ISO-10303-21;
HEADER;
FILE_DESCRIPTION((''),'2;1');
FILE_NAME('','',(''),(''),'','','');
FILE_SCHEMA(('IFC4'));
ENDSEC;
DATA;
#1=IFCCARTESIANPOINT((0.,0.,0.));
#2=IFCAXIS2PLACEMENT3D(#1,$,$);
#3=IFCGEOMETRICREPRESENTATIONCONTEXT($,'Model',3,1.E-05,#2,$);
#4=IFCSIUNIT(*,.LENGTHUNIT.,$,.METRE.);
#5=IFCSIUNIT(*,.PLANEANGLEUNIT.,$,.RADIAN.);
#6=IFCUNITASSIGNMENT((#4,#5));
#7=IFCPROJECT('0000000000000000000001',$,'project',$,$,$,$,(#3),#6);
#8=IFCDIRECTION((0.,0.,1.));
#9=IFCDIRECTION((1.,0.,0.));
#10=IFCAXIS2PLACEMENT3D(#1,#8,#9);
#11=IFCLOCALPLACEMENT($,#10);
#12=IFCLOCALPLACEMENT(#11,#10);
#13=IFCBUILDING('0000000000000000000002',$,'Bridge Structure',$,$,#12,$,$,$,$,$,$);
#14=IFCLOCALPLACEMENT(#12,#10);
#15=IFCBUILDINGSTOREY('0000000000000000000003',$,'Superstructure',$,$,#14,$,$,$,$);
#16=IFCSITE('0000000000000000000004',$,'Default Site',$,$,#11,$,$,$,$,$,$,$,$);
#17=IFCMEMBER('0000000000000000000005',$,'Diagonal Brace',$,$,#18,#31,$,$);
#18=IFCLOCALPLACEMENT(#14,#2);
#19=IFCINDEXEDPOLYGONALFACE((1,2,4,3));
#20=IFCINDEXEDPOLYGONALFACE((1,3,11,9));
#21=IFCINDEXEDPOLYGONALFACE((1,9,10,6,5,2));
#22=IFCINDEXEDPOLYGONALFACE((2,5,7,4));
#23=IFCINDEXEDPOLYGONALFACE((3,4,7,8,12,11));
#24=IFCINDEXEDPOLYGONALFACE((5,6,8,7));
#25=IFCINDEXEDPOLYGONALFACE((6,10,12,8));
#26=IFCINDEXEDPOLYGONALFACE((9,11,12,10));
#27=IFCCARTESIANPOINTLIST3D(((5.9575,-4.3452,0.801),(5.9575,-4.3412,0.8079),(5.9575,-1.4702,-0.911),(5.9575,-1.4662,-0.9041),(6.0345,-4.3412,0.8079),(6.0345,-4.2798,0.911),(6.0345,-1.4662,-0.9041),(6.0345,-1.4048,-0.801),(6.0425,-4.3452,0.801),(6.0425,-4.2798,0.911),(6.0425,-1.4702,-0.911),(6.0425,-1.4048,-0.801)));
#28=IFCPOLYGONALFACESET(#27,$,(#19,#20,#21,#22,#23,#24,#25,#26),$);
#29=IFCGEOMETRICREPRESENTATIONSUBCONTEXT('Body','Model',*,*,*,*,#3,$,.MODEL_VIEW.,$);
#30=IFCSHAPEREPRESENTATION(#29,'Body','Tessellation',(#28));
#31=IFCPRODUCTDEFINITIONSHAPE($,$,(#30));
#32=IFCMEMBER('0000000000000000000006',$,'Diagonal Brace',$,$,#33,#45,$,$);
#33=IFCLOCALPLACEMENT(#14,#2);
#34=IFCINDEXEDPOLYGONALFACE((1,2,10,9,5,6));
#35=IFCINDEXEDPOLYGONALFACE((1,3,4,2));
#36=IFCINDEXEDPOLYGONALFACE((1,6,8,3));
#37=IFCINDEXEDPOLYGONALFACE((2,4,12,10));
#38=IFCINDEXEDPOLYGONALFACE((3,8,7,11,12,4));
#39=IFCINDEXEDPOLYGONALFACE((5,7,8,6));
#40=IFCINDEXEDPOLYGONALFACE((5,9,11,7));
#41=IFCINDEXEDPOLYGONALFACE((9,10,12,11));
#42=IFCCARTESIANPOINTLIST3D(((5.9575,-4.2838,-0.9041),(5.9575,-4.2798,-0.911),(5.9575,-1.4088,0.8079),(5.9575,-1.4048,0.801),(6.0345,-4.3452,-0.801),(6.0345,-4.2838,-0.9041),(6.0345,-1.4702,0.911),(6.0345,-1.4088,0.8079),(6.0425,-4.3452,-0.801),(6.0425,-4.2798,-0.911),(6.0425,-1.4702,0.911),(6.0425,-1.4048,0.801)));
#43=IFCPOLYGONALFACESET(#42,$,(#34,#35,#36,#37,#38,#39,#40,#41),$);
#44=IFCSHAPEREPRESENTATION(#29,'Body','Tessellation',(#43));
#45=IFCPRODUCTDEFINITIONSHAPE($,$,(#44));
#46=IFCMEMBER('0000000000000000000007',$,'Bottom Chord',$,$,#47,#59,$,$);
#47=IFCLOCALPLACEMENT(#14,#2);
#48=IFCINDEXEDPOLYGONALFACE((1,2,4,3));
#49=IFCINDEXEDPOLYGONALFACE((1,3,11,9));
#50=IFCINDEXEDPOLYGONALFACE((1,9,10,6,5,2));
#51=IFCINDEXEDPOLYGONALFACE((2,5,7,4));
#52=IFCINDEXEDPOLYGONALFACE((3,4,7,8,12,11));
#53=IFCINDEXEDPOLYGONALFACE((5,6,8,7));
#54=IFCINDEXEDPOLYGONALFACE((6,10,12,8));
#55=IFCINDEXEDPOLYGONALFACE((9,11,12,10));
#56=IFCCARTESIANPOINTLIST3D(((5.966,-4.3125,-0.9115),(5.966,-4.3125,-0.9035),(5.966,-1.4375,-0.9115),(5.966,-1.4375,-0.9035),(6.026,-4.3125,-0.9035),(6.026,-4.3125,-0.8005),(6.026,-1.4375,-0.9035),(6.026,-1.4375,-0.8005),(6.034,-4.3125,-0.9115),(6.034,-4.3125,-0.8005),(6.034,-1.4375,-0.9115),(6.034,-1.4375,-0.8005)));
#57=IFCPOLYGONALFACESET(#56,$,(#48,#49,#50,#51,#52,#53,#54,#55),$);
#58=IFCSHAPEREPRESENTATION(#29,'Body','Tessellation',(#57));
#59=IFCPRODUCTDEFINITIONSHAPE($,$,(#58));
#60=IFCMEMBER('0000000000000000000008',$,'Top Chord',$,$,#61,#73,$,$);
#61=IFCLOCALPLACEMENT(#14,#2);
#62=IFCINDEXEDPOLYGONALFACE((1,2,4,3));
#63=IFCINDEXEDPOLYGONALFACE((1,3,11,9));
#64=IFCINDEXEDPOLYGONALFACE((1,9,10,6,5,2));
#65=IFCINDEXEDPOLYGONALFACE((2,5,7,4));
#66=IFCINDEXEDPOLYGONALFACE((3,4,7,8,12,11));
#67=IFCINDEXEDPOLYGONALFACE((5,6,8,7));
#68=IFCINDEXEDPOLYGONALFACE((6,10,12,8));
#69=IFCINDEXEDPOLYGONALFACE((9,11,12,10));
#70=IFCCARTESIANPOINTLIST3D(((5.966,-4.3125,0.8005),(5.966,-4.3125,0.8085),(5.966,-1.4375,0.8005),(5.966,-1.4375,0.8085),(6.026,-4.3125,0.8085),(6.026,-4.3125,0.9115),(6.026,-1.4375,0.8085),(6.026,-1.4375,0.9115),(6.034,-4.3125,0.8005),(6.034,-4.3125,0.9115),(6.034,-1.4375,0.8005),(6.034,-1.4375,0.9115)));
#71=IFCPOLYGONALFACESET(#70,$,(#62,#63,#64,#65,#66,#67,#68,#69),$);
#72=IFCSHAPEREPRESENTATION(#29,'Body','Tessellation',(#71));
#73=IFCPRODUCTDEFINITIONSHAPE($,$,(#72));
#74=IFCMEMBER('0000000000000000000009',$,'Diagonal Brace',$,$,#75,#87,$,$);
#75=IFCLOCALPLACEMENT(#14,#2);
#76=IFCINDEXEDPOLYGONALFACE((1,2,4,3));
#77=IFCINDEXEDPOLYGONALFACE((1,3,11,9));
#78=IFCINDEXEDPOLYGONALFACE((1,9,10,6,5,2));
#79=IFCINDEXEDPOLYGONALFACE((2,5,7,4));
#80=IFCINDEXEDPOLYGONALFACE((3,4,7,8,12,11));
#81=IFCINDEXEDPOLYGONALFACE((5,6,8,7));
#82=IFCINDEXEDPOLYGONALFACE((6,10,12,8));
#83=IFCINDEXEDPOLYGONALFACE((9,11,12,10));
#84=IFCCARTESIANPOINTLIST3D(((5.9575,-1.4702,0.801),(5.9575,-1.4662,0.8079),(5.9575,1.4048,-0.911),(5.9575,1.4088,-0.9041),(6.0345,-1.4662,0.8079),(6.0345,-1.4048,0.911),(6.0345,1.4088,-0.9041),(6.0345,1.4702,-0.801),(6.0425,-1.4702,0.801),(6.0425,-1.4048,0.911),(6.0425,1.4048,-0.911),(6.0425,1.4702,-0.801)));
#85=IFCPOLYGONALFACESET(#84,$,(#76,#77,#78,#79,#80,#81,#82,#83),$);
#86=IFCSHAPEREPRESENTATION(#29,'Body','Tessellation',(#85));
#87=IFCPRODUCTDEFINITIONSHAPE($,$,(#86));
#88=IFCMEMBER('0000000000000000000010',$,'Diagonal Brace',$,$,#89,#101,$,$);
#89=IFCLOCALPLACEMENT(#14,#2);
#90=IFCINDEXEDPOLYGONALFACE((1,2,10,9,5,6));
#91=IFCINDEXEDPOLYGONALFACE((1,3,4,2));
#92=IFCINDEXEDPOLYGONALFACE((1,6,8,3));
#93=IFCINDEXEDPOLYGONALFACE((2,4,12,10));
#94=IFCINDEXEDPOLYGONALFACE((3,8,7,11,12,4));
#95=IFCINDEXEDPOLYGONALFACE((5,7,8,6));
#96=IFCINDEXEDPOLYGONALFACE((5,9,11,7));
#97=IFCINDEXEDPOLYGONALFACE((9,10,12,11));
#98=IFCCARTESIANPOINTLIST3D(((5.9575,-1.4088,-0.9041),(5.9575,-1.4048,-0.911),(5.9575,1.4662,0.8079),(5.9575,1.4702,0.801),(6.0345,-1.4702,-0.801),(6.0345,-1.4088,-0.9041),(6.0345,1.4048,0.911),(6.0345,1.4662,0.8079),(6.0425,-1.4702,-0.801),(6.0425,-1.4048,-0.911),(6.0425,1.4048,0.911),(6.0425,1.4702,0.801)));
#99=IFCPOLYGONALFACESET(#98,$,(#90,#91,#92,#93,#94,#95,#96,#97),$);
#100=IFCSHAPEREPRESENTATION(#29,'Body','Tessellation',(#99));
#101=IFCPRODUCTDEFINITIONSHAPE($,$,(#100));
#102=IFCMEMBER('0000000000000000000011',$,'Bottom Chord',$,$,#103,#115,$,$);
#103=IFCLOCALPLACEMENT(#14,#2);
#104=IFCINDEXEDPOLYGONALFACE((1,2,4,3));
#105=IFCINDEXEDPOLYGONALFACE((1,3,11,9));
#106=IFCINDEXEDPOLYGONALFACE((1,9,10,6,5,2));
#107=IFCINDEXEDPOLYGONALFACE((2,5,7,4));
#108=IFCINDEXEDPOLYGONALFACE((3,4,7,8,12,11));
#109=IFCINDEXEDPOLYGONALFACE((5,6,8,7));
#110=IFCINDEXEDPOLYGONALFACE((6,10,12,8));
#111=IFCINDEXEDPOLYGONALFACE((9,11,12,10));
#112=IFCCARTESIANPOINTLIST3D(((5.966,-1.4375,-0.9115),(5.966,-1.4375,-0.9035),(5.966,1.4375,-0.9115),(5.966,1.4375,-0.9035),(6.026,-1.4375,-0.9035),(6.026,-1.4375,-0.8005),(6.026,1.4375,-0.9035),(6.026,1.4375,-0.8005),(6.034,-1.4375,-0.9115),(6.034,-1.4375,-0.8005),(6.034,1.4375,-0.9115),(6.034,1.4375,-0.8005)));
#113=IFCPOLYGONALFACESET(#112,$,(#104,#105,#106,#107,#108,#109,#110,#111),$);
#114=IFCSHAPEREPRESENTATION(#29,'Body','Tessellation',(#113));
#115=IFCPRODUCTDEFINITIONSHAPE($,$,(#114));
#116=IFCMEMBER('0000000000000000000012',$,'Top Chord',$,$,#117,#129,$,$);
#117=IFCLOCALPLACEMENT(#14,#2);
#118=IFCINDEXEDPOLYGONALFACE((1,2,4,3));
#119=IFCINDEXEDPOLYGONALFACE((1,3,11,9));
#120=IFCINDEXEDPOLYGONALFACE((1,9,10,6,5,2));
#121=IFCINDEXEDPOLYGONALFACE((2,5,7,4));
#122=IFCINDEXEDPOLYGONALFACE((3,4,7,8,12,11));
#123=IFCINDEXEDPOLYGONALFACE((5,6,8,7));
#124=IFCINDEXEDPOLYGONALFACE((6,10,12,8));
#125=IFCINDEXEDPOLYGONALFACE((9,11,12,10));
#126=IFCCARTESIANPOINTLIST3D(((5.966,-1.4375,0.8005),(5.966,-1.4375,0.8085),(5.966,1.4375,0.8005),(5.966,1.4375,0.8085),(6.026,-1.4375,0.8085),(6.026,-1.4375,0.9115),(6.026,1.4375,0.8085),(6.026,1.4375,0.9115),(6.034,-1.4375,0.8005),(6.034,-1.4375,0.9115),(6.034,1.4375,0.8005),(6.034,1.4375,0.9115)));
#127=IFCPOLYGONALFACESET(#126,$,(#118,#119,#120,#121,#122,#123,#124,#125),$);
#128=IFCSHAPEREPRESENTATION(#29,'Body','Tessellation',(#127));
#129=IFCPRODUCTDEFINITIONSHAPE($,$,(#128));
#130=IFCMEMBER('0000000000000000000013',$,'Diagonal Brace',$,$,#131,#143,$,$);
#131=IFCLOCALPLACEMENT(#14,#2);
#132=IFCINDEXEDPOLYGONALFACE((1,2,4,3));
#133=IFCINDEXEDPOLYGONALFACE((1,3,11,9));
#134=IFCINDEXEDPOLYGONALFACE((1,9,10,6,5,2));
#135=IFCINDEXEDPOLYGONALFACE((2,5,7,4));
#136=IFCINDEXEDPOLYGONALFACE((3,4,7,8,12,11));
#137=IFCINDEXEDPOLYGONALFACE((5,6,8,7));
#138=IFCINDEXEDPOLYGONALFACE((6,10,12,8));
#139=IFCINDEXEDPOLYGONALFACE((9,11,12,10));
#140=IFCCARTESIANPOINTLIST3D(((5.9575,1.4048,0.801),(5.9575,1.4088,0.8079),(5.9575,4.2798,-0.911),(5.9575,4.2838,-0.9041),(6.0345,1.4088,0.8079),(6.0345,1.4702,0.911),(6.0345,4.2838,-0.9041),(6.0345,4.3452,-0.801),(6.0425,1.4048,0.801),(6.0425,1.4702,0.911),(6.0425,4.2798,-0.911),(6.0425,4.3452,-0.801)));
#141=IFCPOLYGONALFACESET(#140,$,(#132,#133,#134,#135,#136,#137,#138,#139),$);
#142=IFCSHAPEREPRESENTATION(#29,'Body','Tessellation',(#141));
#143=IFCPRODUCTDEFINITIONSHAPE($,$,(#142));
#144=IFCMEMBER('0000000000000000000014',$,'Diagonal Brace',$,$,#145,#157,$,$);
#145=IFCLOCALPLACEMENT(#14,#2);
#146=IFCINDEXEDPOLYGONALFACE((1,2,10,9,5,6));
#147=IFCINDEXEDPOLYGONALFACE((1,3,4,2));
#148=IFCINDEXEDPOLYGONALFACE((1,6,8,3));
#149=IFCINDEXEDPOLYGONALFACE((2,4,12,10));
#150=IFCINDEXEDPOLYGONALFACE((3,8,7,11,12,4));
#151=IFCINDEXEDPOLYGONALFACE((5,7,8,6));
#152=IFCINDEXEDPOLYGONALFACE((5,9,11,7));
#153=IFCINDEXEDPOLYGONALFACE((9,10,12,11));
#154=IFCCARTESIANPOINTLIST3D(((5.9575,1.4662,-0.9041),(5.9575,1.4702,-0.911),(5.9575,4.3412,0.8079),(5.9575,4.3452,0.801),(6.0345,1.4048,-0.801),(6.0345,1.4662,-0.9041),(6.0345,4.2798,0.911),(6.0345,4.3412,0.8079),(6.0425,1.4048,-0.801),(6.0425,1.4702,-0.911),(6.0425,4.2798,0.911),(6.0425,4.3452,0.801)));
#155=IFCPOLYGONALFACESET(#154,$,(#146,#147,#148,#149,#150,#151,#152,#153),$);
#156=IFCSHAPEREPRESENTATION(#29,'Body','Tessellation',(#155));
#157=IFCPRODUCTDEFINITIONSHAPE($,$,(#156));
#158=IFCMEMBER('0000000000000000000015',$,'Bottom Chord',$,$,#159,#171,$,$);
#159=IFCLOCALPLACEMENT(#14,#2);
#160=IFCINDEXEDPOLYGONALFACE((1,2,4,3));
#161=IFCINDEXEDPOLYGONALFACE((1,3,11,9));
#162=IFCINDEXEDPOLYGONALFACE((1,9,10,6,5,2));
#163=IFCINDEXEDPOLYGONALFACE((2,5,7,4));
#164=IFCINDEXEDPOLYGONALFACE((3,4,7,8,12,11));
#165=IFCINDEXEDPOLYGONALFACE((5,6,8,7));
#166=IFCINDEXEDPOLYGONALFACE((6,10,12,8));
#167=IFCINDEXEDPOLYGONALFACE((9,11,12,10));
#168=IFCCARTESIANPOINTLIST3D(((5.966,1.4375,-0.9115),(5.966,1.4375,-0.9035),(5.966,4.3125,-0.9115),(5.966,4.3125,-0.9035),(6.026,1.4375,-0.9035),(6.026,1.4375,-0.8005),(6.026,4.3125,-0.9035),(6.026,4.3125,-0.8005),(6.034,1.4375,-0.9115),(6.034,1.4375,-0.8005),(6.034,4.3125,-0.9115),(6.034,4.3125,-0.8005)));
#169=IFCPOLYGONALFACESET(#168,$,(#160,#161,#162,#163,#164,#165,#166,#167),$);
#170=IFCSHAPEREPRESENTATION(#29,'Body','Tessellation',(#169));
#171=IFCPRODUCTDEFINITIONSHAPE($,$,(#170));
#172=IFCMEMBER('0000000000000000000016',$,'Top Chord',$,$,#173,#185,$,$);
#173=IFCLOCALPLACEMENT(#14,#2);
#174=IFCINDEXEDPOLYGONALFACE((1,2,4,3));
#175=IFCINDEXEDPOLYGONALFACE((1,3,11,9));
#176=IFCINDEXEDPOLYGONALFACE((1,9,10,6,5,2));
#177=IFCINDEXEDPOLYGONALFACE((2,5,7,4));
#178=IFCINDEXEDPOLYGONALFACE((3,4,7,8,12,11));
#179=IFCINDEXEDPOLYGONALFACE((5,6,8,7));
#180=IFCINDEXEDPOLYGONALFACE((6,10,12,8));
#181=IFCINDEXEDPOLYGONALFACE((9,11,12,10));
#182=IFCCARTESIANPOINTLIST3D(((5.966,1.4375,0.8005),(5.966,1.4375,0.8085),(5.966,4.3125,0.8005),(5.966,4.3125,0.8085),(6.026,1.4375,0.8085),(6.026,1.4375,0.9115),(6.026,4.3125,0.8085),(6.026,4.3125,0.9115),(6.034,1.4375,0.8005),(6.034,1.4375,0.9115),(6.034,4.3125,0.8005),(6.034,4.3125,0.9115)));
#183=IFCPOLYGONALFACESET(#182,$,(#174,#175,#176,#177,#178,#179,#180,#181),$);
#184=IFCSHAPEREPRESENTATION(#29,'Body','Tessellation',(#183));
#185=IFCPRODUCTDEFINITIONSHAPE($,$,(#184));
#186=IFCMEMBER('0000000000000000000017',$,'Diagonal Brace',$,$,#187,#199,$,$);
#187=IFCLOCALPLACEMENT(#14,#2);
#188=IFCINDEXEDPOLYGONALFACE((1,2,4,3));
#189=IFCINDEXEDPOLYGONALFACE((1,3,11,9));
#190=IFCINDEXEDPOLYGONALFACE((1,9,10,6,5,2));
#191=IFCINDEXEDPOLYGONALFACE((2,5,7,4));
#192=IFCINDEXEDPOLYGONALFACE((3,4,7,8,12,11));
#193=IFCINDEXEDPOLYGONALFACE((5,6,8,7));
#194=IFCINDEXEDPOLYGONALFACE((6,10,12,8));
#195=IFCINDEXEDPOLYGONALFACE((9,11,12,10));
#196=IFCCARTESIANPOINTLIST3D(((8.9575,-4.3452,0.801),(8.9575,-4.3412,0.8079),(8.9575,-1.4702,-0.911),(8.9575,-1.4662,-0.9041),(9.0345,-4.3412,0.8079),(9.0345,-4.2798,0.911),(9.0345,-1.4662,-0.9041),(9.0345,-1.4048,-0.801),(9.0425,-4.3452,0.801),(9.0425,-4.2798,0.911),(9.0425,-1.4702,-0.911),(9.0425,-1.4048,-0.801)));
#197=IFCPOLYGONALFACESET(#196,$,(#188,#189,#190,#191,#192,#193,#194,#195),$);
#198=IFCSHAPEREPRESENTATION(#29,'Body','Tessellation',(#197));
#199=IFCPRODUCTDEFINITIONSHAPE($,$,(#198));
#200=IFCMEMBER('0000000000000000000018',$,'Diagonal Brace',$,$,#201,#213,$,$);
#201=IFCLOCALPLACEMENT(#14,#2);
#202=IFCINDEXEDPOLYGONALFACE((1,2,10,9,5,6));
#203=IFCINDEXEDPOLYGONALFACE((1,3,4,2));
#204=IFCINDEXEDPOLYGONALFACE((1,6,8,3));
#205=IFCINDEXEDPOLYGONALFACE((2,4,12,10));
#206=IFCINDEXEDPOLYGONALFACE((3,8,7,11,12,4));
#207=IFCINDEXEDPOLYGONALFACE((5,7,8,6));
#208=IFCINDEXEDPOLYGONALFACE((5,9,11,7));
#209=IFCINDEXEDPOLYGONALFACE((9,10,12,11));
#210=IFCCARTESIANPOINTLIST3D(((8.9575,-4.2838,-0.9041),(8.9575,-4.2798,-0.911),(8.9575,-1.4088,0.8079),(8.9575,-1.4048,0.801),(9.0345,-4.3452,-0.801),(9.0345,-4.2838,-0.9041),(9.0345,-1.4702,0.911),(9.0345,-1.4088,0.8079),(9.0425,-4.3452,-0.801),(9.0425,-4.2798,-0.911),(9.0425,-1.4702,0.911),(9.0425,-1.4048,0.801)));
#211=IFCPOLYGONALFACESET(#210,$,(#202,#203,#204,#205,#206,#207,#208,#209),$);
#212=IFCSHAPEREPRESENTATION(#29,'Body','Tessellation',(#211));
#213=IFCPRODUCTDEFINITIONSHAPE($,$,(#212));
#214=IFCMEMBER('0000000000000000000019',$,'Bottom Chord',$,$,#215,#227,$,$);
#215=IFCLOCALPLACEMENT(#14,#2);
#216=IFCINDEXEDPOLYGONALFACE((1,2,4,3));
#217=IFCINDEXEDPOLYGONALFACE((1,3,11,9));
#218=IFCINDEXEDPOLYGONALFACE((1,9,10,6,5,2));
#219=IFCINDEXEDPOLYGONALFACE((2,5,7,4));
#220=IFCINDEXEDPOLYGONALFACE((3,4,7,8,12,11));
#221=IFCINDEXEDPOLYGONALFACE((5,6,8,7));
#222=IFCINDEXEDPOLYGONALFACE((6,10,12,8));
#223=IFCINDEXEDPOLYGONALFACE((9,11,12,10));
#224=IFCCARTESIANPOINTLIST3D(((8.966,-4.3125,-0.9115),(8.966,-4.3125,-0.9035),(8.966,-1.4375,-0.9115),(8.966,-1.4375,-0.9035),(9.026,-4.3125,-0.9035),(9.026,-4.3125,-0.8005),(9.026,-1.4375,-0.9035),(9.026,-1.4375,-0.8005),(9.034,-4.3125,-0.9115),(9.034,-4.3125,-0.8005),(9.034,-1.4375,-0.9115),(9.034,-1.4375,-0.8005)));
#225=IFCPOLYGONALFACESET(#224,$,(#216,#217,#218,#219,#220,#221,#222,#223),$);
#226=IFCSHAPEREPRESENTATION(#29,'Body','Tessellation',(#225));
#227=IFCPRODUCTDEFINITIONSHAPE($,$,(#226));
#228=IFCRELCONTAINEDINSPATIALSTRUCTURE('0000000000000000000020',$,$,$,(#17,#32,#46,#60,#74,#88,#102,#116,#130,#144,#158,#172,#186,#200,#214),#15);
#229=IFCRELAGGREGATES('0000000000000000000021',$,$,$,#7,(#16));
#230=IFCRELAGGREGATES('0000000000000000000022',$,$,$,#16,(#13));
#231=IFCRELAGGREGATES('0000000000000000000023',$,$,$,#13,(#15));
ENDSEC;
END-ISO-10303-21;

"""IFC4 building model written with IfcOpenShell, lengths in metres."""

from ifc_helpers import new_model, si_unit, frame, origin, origin_with_axes, origin_2d_with_axis, place, context, subcontext, project, spatial, l_section, extrude, element, save


model = new_model("IFC4")

# Units and contexts
model_context = context("Model", 3, precision=1e-05, world=origin())
body_context = subcontext(model_context, "Body", "Model", "MODEL_VIEW")
ifc_project = project(units=[si_unit("LENGTHUNIT", "METRE"), si_unit("PLANEANGLEUNIT", "RADIAN")], contexts=[model_context])

# Site, building, storey
site_placement = place(None, origin_with_axes())
site = spatial("IfcSite", under=ifc_project, at=site_placement, Name="Default Site")
building_placement = place(site_placement, origin_with_axes())
building = spatial("IfcBuilding", under=site, at=building_placement, Name="Bridge Structure")
storey_placement = place(building_placement, origin_with_axes())
storey = spatial("IfcBuildingStorey", under=building, at=storey_placement, Name="Superstructure")

# Members
for number, where, z_axis, x_axis, name in (
    (1, (6.0, -4.3125, 0.856), (0.0, 0.859202, -0.511636), (-1.0, 0.0, 0.0), "Diagonal Brace"),
    (2, (6.0, -4.3125, -0.856), (0.0, 0.859202, 0.511636), (-1.0, 0.0, 0.0), "Diagonal Brace"),
):
    element("IfcMember", number, at=place(storey_placement, frame(where, z_axis=z_axis, x_axis=x_axis)), inside=storey, Name=name, context=body_context, shape_type="SweptSolid", body=[
        extrude(l_section(Depth=0.128, Width=0.085, Thickness=0.008, at=origin_2d_with_axis()), origin_with_axes(), (0.0, 0.0, 1.0), 3.3461),
    ])
for number, where, z_axis, x_axis, name in (
    (3, (6.0, -4.3125, -0.856), (0.0, 1.0, 0.0), (-1.0, 0.0, 0.0), "Bottom Chord"),
    (4, (6.0, -4.3125, 0.856), (0.0, 1.0, 0.0), (-1.0, 0.0, 0.0), "Top Chord"),
):
    element("IfcMember", number, at=place(storey_placement, frame(where, z_axis=z_axis, x_axis=x_axis)), inside=storey, Name=name, context=body_context, shape_type="SweptSolid", body=[
        extrude(l_section(Depth=0.111, Width=0.068, Thickness=0.008, at=origin_2d_with_axis()), origin_with_axes(), (0.0, 0.0, 1.0), 2.875),
    ])
for number, where, z_axis, x_axis, name in (
    (5, (6.0, -1.4375, 0.856), (0.0, 0.859202, -0.511636), (-1.0, 0.0, 0.0), "Diagonal Brace"),
    (6, (6.0, -1.4375, -0.856), (0.0, 0.859202, 0.511636), (-1.0, 0.0, 0.0), "Diagonal Brace"),
):
    element("IfcMember", number, at=place(storey_placement, frame(where, z_axis=z_axis, x_axis=x_axis)), inside=storey, Name=name, context=body_context, shape_type="SweptSolid", body=[
        extrude(l_section(Depth=0.128, Width=0.085, Thickness=0.008, at=origin_2d_with_axis()), origin_with_axes(), (0.0, 0.0, 1.0), 3.3461),
    ])
for number, where, z_axis, x_axis, name in (
    (7, (6.0, -1.4375, -0.856), (0.0, 1.0, 0.0), (-1.0, 0.0, 0.0), "Bottom Chord"),
    (8, (6.0, -1.4375, 0.856), (0.0, 1.0, 0.0), (-1.0, 0.0, 0.0), "Top Chord"),
):
    element("IfcMember", number, at=place(storey_placement, frame(where, z_axis=z_axis, x_axis=x_axis)), inside=storey, Name=name, context=body_context, shape_type="SweptSolid", body=[
        extrude(l_section(Depth=0.111, Width=0.068, Thickness=0.008, at=origin_2d_with_axis()), origin_with_axes(), (0.0, 0.0, 1.0), 2.875),
    ])
for number, where, z_axis, x_axis, name in (
    (9, (6.0, 1.4375, 0.856), (0.0, 0.859202, -0.511636), (-1.0, 0.0, 0.0), "Diagonal Brace"),
    (10, (6.0, 1.4375, -0.856), (0.0, 0.859202, 0.511636), (-1.0, 0.0, 0.0), "Diagonal Brace"),
):
    element("IfcMember", number, at=place(storey_placement, frame(where, z_axis=z_axis, x_axis=x_axis)), inside=storey, Name=name, context=body_context, shape_type="SweptSolid", body=[
        extrude(l_section(Depth=0.128, Width=0.085, Thickness=0.008, at=origin_2d_with_axis()), origin_with_axes(), (0.0, 0.0, 1.0), 3.3461),
    ])
for number, where, z_axis, x_axis, name in (
    (11, (6.0, 1.4375, -0.856), (0.0, 1.0, 0.0), (-1.0, 0.0, 0.0), "Bottom Chord"),
    (12, (6.0, 1.4375, 0.856), (0.0, 1.0, 0.0), (-1.0, 0.0, 0.0), "Top Chord"),
):
    element("IfcMember", number, at=place(storey_placement, frame(where, z_axis=z_axis, x_axis=x_axis)), inside=storey, Name=name, context=body_context, shape_type="SweptSolid", body=[
        extrude(l_section(Depth=0.111, Width=0.068, Thickness=0.008, at=origin_2d_with_axis()), origin_with_axes(), (0.0, 0.0, 1.0), 2.875),
    ])
for number, where, z_axis, x_axis, name in (
    (13, (9.0, -4.3125, 0.856), (0.0, 0.859202, -0.511636), (-1.0, 0.0, 0.0), "Diagonal Brace"),
    (14, (9.0, -4.3125, -0.856), (0.0, 0.859202, 0.511636), (-1.0, 0.0, 0.0), "Diagonal Brace"),
):
    element("IfcMember", number, at=place(storey_placement, frame(where, z_axis=z_axis, x_axis=x_axis)), inside=storey, Name=name, context=body_context, shape_type="SweptSolid", body=[
        extrude(l_section(Depth=0.128, Width=0.085, Thickness=0.008, at=origin_2d_with_axis()), origin_with_axes(), (0.0, 0.0, 1.0), 3.3461),
    ])
for number, where, z_axis, x_axis, name in (
    (15, (9.0, -4.3125, -0.856), (0.0, 1.0, 0.0), (-1.0, 0.0, 0.0), "Bottom Chord"),
):
    element("IfcMember", number, at=place(storey_placement, frame(where, z_axis=z_axis, x_axis=x_axis)), inside=storey, Name=name, context=body_context, shape_type="SweptSolid", body=[
        extrude(l_section(Depth=0.111, Width=0.068, Thickness=0.008, at=origin_2d_with_axis()), origin_with_axes(), (0.0, 0.0, 1.0), 2.875),
    ])

save(model, "model.ifc")
